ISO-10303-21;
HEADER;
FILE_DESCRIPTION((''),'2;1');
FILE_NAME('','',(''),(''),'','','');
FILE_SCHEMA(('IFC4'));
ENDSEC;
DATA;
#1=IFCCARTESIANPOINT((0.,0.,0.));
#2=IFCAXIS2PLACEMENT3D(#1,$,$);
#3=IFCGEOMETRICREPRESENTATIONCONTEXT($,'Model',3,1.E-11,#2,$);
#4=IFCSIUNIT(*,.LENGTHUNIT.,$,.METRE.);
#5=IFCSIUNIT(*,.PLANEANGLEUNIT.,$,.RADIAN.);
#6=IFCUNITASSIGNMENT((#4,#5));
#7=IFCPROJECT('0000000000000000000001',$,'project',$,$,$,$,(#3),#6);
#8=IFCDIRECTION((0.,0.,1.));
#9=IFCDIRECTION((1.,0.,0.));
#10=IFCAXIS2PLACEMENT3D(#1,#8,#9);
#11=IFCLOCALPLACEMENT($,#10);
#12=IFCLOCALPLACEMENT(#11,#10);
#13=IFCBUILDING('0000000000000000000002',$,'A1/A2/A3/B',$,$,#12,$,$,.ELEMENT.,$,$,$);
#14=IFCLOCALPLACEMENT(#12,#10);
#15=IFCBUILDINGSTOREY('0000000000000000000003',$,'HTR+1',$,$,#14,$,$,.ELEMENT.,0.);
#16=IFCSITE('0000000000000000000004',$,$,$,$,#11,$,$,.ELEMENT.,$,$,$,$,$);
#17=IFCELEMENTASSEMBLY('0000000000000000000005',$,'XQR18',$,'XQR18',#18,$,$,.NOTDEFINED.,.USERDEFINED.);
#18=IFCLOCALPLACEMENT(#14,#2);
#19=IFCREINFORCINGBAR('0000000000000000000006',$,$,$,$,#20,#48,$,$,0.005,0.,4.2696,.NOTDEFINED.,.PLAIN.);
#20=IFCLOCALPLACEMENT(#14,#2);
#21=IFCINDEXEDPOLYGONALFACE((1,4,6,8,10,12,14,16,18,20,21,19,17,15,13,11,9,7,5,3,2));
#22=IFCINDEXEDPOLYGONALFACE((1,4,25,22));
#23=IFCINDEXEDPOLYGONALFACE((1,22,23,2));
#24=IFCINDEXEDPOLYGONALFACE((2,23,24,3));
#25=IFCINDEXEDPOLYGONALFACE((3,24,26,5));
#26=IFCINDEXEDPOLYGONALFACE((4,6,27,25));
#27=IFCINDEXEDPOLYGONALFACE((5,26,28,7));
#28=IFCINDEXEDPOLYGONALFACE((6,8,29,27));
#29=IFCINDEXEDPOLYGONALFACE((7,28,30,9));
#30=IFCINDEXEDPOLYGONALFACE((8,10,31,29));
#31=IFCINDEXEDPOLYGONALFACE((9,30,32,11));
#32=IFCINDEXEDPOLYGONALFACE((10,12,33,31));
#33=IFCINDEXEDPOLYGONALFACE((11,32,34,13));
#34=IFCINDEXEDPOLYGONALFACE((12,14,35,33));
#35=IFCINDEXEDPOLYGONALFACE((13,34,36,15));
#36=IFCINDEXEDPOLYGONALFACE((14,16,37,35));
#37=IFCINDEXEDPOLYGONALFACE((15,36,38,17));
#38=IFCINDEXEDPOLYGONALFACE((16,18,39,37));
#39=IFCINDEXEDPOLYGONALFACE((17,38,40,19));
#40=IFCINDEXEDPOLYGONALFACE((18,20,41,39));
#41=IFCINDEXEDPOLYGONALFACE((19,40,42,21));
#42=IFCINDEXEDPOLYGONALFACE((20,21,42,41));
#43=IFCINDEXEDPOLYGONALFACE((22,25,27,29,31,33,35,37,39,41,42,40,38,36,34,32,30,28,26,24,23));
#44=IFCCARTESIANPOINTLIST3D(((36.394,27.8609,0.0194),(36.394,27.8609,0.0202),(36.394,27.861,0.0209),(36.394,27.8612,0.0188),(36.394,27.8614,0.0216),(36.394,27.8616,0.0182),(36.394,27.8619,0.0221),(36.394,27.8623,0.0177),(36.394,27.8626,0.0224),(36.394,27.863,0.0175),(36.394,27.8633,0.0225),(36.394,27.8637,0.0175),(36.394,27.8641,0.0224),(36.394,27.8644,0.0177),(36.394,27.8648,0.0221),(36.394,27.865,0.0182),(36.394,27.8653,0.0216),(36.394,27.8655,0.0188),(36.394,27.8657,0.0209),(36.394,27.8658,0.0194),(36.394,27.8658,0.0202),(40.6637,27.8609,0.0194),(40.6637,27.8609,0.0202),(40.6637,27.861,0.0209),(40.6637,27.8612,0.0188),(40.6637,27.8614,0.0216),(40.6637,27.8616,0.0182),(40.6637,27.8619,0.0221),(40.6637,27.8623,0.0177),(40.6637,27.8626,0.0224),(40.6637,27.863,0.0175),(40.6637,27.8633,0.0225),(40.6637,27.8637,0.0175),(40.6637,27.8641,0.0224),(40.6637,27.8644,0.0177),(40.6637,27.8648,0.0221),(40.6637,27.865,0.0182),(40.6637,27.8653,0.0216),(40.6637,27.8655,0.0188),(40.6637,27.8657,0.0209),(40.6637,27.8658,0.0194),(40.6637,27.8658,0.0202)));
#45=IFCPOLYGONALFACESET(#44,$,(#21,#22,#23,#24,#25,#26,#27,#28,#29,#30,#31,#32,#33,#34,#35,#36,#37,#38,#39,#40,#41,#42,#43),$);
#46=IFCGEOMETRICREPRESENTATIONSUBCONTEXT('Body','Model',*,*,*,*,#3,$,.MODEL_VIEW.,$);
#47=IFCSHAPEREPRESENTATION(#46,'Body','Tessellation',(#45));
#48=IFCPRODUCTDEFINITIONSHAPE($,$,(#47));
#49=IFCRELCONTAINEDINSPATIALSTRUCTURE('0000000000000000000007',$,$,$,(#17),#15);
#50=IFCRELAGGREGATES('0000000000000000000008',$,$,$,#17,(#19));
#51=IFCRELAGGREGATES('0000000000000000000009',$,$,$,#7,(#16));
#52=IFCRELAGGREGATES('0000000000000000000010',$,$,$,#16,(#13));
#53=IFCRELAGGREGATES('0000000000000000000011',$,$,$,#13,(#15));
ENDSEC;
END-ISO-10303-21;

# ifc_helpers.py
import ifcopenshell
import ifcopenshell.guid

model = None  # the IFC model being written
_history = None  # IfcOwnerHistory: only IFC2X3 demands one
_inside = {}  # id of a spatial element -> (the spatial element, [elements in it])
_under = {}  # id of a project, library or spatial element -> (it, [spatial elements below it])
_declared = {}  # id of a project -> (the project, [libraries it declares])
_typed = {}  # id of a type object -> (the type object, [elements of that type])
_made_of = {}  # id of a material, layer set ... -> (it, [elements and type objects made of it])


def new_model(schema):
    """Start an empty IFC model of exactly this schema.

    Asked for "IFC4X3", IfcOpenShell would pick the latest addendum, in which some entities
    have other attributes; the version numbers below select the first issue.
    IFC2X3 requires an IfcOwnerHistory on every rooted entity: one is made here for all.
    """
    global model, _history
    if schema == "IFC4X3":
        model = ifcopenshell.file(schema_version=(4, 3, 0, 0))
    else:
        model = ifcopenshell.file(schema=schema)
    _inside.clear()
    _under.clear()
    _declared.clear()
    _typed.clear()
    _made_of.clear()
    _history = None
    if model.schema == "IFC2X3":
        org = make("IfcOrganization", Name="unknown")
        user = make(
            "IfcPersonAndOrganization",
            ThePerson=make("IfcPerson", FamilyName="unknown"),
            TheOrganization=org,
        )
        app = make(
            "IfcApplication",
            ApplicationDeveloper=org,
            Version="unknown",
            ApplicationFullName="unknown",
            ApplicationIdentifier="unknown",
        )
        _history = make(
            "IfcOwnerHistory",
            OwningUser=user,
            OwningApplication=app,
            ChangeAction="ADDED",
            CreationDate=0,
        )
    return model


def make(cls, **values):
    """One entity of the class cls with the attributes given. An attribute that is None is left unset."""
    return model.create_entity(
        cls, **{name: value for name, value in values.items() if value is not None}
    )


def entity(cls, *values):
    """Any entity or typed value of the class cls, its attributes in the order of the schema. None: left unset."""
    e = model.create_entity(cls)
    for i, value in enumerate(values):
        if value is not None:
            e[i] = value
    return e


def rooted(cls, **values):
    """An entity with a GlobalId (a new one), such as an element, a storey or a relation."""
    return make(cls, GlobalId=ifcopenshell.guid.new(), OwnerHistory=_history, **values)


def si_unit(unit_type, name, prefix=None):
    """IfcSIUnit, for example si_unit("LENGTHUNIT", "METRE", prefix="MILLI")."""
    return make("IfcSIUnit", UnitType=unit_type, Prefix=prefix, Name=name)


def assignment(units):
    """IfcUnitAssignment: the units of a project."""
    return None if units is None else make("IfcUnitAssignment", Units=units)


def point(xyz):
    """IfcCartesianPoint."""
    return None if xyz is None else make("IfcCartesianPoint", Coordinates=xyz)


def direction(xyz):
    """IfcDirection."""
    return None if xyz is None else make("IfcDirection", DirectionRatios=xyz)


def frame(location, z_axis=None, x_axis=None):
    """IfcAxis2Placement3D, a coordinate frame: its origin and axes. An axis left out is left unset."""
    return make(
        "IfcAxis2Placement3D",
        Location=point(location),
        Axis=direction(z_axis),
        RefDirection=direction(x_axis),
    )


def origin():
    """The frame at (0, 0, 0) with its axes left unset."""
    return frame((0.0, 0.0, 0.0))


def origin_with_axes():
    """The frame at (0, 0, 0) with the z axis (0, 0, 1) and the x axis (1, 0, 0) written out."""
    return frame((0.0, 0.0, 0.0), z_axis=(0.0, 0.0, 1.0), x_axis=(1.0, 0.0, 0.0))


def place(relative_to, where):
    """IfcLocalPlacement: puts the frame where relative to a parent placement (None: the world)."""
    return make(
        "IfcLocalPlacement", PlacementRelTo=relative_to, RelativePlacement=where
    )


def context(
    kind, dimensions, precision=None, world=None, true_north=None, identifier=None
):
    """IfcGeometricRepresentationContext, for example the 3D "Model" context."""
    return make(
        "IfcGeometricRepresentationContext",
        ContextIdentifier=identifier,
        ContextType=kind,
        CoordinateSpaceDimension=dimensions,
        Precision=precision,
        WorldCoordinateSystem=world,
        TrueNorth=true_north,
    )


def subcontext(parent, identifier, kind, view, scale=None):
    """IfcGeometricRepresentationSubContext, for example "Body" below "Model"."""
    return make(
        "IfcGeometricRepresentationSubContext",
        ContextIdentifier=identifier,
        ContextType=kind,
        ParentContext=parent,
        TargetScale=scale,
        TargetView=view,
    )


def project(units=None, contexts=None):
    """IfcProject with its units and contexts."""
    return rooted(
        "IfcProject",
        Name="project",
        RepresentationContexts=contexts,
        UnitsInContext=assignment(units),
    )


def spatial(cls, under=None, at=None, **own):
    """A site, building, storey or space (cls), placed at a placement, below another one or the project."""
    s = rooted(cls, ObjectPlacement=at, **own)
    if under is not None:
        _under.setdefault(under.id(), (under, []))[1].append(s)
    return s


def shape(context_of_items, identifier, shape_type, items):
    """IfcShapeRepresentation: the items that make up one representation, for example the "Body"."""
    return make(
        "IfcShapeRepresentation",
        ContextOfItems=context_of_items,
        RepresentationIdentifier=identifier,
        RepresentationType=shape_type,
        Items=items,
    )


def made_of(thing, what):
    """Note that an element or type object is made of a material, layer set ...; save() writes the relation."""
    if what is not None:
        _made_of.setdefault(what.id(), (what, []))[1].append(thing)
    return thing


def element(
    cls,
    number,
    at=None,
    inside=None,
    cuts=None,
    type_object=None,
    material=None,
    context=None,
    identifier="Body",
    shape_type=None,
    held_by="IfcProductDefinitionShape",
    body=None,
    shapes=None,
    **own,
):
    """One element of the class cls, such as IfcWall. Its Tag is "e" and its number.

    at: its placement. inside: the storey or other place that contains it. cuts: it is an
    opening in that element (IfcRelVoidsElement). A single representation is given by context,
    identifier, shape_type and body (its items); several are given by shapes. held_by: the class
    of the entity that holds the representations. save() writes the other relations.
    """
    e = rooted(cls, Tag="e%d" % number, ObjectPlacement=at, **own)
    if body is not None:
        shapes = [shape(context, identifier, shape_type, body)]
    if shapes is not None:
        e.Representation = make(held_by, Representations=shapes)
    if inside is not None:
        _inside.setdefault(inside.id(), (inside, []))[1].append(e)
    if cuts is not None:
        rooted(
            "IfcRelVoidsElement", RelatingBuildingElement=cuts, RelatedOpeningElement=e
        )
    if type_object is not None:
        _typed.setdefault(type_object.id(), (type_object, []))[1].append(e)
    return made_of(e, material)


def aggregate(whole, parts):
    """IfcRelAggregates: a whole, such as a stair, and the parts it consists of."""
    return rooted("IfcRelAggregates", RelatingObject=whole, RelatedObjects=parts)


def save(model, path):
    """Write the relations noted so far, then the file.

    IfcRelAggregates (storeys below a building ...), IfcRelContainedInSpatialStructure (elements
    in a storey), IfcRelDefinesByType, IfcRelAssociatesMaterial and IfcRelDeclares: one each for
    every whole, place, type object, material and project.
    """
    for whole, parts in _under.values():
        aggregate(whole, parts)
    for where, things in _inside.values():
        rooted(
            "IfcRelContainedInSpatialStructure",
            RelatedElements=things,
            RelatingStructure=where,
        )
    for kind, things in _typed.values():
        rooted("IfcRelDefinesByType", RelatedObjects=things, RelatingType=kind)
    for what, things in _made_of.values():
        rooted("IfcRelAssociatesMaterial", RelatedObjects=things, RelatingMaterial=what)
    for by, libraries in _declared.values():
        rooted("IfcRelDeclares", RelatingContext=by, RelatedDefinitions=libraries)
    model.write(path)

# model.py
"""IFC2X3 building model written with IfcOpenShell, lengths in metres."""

from ifc_helpers import new_model, entity, si_unit, origin, origin_with_axes, place, context, subcontext, project, spatial, shape, element, aggregate, save


model = new_model("IFC2X3")

# Units and contexts
model_context = context("Model", 3, precision=1e-11, world=origin())
body_context = subcontext(model_context, "Body", "Model", "MODEL_VIEW")
ifc_project = project(units=[si_unit("LENGTHUNIT", "METRE"), si_unit("PLANEANGLEUNIT", "RADIAN")], contexts=[model_context])

# Site, building, storey
site_placement = place(None, origin_with_axes())
site = spatial("IfcSite", under=ifc_project, at=site_placement, CompositionType="ELEMENT")
building_placement = place(site_placement, origin_with_axes())
building = spatial("IfcBuilding", under=site, at=building_placement, Name="A1/A2/A3/B", CompositionType="ELEMENT")
storey_placement = place(building_placement, origin_with_axes())
storey = spatial("IfcBuildingStorey", under=building, at=storey_placement, Name="HTR+1", CompositionType="ELEMENT", Elevation=0.0)

# Element assembly, reinforcing bar
assembly_1_placement = place(storey_placement, origin_with_axes())
assembly_1 = element("IfcElementAssembly", 1, at=assembly_1_placement, inside=storey, Name="XQR18", ObjectType="XQR18", AssemblyPlace="NOTDEFINED", PredefinedType="USERDEFINED")
reinforcing_bar_1_placement = place(assembly_1_placement, origin_with_axes())
reinforcing_bar_1 = element("IfcReinforcingBar", 2, at=reinforcing_bar_1_placement, BarLength=4.2696, BarRole="NOTDEFINED", BarSurface="PLAIN", CrossSectionArea=0.0, NominalDiameter=0.005, shapes=[
    shape(body_context, "Body", "AdvancedSweptSolid", [entity("IfcSweptDiskSolid", entity("IfcPolyline", [entity("IfcCartesianPoint", [36.394, 27.8633, 0.02]), entity("IfcCartesianPoint", [40.6637, 27.8633, 0.02])]), 0.0025, None, 0.0, 4.2696)]),
    shape(body_context, "Body", "AdvancedSweptSolid", [entity("IfcSweptDiskSolid", entity("IfcPolyline", [entity("IfcCartesianPoint", [36.394, 27.8633, 0.02]), entity("IfcCartesianPoint", [40.6637, 27.8633, 0.02])]), 0.0025, None, 0.0, 4.2696)]),
])
aggregate(assembly_1, [reinforcing_bar_1])

save(model, "model.ifc")
